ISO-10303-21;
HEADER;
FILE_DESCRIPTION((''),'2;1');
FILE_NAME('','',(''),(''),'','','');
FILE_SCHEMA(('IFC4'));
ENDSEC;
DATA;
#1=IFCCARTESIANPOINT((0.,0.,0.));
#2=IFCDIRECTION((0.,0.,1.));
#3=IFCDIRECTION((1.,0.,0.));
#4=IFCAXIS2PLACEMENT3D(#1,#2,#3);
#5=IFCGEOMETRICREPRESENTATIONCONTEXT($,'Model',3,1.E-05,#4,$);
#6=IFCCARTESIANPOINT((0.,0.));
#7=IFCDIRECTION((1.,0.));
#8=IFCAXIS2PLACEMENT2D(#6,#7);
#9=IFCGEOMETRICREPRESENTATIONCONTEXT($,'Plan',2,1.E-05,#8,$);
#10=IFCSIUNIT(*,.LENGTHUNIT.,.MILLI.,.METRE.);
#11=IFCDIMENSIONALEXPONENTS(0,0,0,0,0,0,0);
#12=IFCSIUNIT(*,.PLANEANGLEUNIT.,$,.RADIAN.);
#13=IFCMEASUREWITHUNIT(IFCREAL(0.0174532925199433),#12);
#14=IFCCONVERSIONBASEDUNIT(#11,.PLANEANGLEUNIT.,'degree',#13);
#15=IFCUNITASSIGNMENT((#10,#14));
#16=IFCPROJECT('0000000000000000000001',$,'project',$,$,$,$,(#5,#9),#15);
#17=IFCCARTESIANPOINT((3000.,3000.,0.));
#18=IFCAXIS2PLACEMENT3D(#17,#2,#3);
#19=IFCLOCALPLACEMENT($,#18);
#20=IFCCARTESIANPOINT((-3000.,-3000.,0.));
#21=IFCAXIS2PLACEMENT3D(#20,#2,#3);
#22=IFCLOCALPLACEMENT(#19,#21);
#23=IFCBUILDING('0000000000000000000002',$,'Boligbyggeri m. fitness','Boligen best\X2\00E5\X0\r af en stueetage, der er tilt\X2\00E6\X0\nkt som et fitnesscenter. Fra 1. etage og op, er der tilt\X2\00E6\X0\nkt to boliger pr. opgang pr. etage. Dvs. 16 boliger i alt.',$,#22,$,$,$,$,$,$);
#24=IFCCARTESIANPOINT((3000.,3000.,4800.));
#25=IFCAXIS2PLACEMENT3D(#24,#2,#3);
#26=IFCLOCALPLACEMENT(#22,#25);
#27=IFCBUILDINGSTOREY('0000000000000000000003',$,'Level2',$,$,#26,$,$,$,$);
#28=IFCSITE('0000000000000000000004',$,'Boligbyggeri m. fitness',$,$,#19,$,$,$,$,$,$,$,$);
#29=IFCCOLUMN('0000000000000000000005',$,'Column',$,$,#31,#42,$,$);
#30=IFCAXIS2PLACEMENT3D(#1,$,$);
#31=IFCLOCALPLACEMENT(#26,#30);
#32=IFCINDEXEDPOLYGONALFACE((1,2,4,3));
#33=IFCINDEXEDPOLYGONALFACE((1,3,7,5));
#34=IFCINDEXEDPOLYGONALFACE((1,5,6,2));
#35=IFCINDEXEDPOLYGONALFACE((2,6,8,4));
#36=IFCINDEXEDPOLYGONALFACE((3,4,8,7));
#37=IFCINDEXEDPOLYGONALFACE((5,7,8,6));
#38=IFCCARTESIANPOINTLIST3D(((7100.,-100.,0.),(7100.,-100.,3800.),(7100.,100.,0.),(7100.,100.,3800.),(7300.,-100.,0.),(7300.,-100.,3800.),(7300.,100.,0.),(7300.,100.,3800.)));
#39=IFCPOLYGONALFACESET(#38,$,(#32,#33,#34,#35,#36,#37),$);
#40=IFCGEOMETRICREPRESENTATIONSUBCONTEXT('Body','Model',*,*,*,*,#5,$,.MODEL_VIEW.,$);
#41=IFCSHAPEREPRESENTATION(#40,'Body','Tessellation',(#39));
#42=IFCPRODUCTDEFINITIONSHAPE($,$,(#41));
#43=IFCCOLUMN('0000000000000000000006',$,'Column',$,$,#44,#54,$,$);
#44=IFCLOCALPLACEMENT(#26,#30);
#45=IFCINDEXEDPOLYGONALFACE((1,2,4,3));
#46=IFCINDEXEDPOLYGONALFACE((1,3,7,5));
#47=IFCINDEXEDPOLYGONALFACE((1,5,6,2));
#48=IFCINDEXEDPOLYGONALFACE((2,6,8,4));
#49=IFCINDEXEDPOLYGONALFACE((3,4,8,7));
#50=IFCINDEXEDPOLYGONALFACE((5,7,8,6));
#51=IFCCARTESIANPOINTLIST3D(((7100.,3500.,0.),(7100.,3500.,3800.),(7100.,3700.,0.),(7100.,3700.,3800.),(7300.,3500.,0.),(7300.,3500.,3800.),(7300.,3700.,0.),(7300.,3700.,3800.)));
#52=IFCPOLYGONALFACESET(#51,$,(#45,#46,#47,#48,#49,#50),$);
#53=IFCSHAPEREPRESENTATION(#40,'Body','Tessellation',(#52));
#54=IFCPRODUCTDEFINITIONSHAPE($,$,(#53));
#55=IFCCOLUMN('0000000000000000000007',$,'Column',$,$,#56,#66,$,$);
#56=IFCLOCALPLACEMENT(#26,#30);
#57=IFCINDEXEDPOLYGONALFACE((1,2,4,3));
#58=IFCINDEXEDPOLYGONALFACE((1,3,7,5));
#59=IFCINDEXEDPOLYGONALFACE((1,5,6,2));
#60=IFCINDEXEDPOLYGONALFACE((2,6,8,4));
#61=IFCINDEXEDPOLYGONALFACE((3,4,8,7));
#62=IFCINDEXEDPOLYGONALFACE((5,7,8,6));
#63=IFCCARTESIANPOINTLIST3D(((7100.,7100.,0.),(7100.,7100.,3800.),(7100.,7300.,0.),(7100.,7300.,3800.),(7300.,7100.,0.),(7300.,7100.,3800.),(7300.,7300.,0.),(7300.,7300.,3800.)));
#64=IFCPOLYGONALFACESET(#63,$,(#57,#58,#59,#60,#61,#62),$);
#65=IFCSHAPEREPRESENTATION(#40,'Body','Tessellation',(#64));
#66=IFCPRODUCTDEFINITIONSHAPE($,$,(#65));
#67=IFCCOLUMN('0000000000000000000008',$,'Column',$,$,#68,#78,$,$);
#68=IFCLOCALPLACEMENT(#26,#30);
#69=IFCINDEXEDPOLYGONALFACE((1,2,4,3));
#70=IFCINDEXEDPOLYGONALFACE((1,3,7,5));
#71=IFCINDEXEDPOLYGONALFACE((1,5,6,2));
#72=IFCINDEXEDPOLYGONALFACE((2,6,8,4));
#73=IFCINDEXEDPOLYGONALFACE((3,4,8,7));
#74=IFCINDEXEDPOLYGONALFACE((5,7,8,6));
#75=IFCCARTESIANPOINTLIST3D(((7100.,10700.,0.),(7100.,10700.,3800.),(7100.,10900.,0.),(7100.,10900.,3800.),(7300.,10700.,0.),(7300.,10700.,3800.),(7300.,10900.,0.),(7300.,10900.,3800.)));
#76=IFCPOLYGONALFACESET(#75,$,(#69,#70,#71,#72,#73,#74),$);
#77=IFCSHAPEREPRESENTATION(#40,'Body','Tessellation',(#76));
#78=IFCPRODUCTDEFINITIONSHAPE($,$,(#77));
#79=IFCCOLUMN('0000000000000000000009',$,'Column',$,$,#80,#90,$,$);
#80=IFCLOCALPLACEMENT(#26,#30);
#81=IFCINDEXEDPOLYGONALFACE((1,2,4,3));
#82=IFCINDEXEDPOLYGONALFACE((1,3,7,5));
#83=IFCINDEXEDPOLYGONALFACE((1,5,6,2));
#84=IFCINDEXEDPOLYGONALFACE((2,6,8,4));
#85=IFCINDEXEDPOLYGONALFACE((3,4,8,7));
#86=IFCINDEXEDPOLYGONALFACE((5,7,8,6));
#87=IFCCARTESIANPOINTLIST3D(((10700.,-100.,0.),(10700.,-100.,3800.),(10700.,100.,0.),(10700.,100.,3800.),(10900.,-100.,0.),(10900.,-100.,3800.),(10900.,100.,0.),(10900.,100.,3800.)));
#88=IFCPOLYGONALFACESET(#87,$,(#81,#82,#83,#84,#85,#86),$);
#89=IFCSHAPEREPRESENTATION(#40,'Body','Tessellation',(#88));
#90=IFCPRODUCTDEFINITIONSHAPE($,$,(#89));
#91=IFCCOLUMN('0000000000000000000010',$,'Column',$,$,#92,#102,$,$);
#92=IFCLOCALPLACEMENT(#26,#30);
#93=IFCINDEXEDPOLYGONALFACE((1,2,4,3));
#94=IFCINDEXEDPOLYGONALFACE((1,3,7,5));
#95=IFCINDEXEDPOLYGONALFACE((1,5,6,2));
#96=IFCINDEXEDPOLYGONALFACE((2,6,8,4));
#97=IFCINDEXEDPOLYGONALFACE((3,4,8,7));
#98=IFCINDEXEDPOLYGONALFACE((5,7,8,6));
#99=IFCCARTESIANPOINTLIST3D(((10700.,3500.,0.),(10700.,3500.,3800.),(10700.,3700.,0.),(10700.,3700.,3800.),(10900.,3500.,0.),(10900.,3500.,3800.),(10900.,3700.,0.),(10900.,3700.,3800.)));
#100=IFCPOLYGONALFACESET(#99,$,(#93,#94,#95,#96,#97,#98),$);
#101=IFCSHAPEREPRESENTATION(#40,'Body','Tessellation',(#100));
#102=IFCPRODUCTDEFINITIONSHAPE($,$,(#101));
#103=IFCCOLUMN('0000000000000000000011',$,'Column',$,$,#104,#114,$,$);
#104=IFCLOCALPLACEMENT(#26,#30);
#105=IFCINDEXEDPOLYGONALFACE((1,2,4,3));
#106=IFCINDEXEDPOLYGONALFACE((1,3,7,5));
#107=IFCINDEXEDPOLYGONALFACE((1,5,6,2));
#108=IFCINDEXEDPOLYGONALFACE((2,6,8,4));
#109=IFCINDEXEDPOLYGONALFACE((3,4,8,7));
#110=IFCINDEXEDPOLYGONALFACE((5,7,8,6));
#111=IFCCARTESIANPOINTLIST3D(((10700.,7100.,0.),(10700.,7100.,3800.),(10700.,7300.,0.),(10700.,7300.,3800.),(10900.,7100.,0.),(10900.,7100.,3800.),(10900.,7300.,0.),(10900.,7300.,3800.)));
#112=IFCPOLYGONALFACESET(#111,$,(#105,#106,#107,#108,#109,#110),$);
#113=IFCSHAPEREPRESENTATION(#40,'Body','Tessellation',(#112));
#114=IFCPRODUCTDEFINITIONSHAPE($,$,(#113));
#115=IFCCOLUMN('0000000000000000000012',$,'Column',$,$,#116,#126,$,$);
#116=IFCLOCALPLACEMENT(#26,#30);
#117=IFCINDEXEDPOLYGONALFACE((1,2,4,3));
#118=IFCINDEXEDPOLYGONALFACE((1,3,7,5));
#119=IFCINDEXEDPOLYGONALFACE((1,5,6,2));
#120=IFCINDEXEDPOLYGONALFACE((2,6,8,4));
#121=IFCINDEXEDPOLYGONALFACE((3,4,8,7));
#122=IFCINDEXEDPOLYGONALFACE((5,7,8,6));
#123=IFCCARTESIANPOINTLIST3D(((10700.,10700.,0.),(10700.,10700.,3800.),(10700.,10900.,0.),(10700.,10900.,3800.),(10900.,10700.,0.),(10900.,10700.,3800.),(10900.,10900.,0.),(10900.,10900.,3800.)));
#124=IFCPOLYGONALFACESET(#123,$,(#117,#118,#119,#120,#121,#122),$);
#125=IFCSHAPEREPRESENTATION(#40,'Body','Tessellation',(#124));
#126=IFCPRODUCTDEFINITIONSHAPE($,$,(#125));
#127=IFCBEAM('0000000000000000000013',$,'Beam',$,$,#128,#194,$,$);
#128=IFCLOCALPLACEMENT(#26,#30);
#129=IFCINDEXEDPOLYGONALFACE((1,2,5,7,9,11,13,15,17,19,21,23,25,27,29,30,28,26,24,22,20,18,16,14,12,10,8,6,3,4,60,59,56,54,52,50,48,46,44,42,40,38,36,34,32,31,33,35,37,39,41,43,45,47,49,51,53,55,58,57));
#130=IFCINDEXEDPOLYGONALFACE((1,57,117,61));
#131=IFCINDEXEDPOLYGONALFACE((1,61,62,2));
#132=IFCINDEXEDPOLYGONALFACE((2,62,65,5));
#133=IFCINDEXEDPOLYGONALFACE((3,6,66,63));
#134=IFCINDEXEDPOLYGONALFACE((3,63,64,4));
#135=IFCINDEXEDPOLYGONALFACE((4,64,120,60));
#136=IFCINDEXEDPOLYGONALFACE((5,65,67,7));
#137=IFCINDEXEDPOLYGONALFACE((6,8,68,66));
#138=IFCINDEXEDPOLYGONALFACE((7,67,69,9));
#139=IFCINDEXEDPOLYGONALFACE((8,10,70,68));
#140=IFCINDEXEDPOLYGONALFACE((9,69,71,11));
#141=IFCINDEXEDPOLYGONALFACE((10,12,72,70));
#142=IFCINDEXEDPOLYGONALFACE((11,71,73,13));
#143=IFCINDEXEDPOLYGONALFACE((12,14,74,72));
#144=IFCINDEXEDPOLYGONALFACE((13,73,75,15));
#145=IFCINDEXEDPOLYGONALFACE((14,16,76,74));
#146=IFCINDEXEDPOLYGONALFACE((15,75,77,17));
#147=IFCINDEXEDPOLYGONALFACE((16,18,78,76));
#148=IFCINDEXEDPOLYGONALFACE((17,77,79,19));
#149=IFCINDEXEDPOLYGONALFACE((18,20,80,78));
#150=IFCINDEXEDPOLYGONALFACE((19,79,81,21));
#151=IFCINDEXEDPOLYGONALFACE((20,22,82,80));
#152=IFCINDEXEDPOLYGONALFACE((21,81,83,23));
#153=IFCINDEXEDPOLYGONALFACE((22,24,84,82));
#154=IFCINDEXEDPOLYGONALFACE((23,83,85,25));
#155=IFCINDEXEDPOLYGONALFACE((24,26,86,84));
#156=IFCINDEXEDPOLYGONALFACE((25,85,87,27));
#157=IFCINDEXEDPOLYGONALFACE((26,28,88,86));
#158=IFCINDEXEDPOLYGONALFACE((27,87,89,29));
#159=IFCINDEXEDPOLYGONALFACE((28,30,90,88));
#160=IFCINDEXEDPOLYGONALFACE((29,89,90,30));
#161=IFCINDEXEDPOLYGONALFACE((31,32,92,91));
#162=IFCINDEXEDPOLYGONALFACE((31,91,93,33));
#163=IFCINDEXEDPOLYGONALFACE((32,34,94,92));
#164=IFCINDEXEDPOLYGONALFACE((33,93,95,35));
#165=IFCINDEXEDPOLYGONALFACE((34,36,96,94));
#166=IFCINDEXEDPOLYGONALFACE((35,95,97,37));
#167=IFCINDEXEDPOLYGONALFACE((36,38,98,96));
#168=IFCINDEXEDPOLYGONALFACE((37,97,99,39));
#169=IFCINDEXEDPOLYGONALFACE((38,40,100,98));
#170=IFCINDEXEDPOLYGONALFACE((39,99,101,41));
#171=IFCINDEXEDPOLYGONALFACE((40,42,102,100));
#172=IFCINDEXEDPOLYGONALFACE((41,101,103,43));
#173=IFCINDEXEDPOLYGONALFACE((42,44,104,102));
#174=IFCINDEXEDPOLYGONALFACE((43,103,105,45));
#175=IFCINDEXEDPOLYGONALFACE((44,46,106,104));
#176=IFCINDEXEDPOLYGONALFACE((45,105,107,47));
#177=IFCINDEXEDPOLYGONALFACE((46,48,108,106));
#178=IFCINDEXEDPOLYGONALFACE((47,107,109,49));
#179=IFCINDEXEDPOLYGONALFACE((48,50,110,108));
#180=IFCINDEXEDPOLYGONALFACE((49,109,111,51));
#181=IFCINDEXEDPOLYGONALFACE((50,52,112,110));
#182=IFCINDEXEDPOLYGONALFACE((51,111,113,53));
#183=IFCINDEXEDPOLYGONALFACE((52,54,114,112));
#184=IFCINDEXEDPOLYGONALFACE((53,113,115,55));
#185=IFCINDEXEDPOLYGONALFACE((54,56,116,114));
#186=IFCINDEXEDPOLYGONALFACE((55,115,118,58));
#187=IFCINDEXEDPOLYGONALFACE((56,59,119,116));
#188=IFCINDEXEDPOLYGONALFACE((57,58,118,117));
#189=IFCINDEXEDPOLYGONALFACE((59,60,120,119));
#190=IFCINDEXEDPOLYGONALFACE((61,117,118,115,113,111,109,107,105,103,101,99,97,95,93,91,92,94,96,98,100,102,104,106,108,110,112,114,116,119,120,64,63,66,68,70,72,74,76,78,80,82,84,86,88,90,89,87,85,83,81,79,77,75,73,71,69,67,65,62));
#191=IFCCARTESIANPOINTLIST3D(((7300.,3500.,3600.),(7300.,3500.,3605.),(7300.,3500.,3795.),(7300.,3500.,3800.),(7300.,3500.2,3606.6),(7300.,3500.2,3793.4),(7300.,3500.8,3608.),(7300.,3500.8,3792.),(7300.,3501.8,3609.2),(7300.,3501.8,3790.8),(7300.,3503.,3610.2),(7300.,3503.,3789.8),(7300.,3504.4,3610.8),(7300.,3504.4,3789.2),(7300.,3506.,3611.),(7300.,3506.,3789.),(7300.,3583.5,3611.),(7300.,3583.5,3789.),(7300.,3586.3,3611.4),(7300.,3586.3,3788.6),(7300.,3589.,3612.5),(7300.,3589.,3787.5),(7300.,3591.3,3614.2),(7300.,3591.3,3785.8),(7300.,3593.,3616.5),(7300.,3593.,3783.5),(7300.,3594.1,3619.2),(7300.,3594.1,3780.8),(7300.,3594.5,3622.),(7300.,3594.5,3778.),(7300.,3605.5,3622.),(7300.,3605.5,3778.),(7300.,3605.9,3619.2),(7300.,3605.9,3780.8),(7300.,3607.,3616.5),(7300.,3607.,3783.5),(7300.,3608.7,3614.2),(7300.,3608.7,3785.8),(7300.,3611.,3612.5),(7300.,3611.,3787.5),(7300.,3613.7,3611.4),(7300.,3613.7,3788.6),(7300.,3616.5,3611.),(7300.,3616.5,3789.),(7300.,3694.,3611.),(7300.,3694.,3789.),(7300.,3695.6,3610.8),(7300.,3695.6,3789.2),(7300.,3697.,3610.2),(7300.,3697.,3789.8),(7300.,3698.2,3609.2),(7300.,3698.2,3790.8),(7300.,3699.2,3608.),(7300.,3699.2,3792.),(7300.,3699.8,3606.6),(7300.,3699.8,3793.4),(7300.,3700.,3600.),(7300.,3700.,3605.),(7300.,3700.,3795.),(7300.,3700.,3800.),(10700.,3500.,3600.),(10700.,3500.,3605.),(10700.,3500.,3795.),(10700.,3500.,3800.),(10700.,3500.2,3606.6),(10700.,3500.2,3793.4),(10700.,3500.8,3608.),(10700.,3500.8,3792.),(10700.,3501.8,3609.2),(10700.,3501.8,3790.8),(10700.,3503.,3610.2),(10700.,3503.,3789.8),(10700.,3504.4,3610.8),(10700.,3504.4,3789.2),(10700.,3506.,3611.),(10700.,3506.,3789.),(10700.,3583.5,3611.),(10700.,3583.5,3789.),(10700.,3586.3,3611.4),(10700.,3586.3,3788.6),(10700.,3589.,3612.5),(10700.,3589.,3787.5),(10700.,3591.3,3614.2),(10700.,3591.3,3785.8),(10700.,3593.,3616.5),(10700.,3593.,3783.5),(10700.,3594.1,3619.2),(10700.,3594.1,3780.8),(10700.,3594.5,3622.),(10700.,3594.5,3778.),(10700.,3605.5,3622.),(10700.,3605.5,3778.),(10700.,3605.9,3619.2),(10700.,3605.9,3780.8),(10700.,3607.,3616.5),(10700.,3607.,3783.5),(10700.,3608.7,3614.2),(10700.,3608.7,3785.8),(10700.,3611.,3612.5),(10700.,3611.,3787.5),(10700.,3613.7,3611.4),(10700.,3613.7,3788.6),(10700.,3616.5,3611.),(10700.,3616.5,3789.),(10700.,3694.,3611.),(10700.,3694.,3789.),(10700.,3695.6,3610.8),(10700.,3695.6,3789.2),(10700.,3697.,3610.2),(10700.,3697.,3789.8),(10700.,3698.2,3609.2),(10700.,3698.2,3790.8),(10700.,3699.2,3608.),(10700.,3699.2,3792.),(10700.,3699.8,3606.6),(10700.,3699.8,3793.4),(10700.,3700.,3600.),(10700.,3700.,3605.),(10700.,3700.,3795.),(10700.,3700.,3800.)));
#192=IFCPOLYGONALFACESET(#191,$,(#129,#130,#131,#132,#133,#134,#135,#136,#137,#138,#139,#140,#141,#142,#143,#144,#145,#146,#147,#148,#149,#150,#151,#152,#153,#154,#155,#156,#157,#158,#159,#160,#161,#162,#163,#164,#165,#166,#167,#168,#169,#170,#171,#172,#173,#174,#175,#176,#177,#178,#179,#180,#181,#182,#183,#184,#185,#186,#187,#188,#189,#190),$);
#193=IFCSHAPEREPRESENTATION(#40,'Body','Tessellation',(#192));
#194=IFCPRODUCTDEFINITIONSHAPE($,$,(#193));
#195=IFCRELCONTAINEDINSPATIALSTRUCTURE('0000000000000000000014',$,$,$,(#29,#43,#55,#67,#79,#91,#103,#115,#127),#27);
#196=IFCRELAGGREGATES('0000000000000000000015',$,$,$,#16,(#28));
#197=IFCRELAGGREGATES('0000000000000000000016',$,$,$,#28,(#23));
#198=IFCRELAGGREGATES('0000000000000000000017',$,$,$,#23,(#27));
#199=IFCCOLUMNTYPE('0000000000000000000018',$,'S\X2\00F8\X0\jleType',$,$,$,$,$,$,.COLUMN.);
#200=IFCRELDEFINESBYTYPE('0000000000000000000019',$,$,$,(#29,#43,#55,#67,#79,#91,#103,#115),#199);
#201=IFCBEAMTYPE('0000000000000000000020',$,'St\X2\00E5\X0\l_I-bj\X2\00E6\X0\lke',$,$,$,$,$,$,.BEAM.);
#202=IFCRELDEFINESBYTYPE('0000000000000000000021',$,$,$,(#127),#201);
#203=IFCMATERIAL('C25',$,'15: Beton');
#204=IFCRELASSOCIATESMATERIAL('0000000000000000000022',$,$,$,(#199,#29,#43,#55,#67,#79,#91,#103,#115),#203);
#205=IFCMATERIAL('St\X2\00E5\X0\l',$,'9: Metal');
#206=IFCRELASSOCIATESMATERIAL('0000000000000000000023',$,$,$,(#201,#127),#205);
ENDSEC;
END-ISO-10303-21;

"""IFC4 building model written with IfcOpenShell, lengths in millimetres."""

from ifc_helpers import new_model, entity, si_unit, converted_unit, frame, origin_with_axes, origin_2d_with_axis, place, context, subcontext, project, spatial, rectangle, i_section, extrude, material, material_profile, profile_set, profile_usage, type_object, element, save


model = new_model("IFC4")

# Units and contexts
model_context = context("Model", 3, precision=1e-05, world=origin_with_axes())
plan_context = context("Plan", 2, precision=1e-05, world=origin_2d_with_axis())
body_context = subcontext(model_context, "Body", "Model", "MODEL_VIEW")
ifc_project = project(units=[si_unit("LENGTHUNIT", "METRE", prefix="MILLI"), converted_unit("PLANEANGLEUNIT", "degree", entity("IfcReal", 0.0174532925199433), si_unit("PLANEANGLEUNIT", "RADIAN"), dimensions=[0, 0, 0, 0, 0, 0, 0])], contexts=[model_context, plan_context])

# Site, building, storey
site_placement = place(None, frame((3000.0, 3000.0, 0.0), z_axis=(0.0, 0.0, 1.0), x_axis=(1.0, 0.0, 0.0)))
site = spatial("IfcSite", under=ifc_project, at=site_placement, Name="Boligbyggeri m. fitness")
building_placement = place(site_placement, frame((-3000.0, -3000.0, 0.0), z_axis=(0.0, 0.0, 1.0), x_axis=(1.0, 0.0, 0.0)))
building = spatial("IfcBuilding", under=site, at=building_placement, Name="Boligbyggeri m. fitness", Description="Boligen består af en stueetage, der er tiltænkt som et fitnesscenter. Fra 1. etage og op, er der tiltænkt to boliger pr. opgang pr. etage. Dvs. 16 boliger i alt.")
storey_placement = place(building_placement, frame((3000.0, 3000.0, 4800.0), z_axis=(0.0, 0.0, 1.0), x_axis=(1.0, 0.0, 0.0)))
storey = spatial("IfcBuildingStorey", under=building, at=storey_placement, Name="Level2")

# Columns
ifc_material_1 = material(Name="C25", Category="15: Beton")
ifc_material_profile_1 = material_profile(ifc_material_1, rectangle(XDim=200.0, YDim=200.0), Name="SøjleBeton", Category="15: Beton")
ifc_profile_set_1 = profile_set([ifc_material_profile_1], Name="200x200")
ifc_profile_usage_1 = profile_usage(ifc_profile_set_1, cardinal=5)
column_type = type_object("IfcColumnType", Name="SøjleType", PredefinedType="COLUMN", material=ifc_profile_set_1)
column_1_placement = place(storey_placement, frame((7200.0, 0.0, 0.0), z_axis=(0.0, 0.0, 1.0), x_axis=(1.0, 0.0, 0.0)))
element("IfcColumn", 1, at=column_1_placement, inside=storey, type_object=column_type, material=ifc_profile_usage_1, Name="Column", context=body_context, shape_type="SweptSolid", body=[
    extrude(rectangle(XDim=200.0, YDim=200.0), origin_with_axes(), (0.0, 0.0, 1.0), 3800.0),
])
ifc_profile_usage_2 = profile_usage(ifc_profile_set_1, cardinal=5)
column_2_placement = place(storey_placement, frame((7200.0, 3600.0, 0.0), z_axis=(0.0, 0.0, 1.0), x_axis=(1.0, 0.0, 0.0)))
element("IfcColumn", 2, at=column_2_placement, inside=storey, type_object=column_type, material=ifc_profile_usage_2, Name="Column", context=body_context, shape_type="SweptSolid", body=[
    extrude(rectangle(XDim=200.0, YDim=200.0), origin_with_axes(), (0.0, 0.0, 1.0), 3800.0),
])
ifc_profile_usage_3 = profile_usage(ifc_profile_set_1, cardinal=5)
column_3_placement = place(storey_placement, frame((7200.0, 7200.0, 0.0), z_axis=(0.0, 0.0, 1.0), x_axis=(1.0, 0.0, 0.0)))
element("IfcColumn", 3, at=column_3_placement, inside=storey, type_object=column_type, material=ifc_profile_usage_3, Name="Column", context=body_context, shape_type="SweptSolid", body=[
    extrude(rectangle(XDim=200.0, YDim=200.0), origin_with_axes(), (0.0, 0.0, 1.0), 3800.0),
])
ifc_profile_usage_4 = profile_usage(ifc_profile_set_1, cardinal=5)
column_4_placement = place(storey_placement, frame((7200.0, 10800.0, 0.0), z_axis=(0.0, 0.0, 1.0), x_axis=(1.0, 0.0, 0.0)))
element("IfcColumn", 4, at=column_4_placement, inside=storey, type_object=column_type, material=ifc_profile_usage_4, Name="Column", context=body_context, shape_type="SweptSolid", body=[
    extrude(rectangle(XDim=200.0, YDim=200.0), origin_with_axes(), (0.0, 0.0, 1.0), 3800.0),
])
ifc_profile_usage_5 = profile_usage(ifc_profile_set_1, cardinal=5)
column_5_placement = place(storey_placement, frame((10800.0, 0.0, 0.0), z_axis=(0.0, 0.0, 1.0), x_axis=(1.0, 0.0, 0.0)))
element("IfcColumn", 5, at=column_5_placement, inside=storey, type_object=column_type, material=ifc_profile_usage_5, Name="Column", context=body_context, shape_type="SweptSolid", body=[
    extrude(rectangle(XDim=200.0, YDim=200.0), origin_with_axes(), (0.0, 0.0, 1.0), 3800.0),
])
ifc_profile_usage_6 = profile_usage(ifc_profile_set_1, cardinal=5)
column_6_placement = place(storey_placement, frame((10800.0, 3600.0, 0.0), z_axis=(0.0, 0.0, 1.0), x_axis=(1.0, 0.0, 0.0)))
element("IfcColumn", 6, at=column_6_placement, inside=storey, type_object=column_type, material=ifc_profile_usage_6, Name="Column", context=body_context, shape_type="SweptSolid", body=[
    extrude(rectangle(XDim=200.0, YDim=200.0), origin_with_axes(), (0.0, 0.0, 1.0), 3800.0),
])
ifc_profile_usage_7 = profile_usage(ifc_profile_set_1, cardinal=5)
column_7_placement = place(storey_placement, frame((10800.0, 7200.0, 0.0), z_axis=(0.0, 0.0, 1.0), x_axis=(1.0, 0.0, 0.0)))
element("IfcColumn", 7, at=column_7_placement, inside=storey, type_object=column_type, material=ifc_profile_usage_7, Name="Column", context=body_context, shape_type="SweptSolid", body=[
    extrude(rectangle(XDim=200.0, YDim=200.0), origin_with_axes(), (0.0, 0.0, 1.0), 3800.0),
])
ifc_profile_usage_8 = profile_usage(ifc_profile_set_1, cardinal=5)
column_8_placement = place(storey_placement, frame((10800.0, 10800.0, 0.0), z_axis=(0.0, 0.0, 1.0), x_axis=(1.0, 0.0, 0.0)))
element("IfcColumn", 8, at=column_8_placement, inside=storey, type_object=column_type, material=ifc_profile_usage_8, Name="Column", context=body_context, shape_type="SweptSolid", body=[
    extrude(rectangle(XDim=200.0, YDim=200.0), origin_with_axes(), (0.0, 0.0, 1.0), 3800.0),
])

# Beam
ifc_material_2 = material(Name="Stål", Category="9: Metal")
ifc_material_profile_2 = material_profile(ifc_material_2, i_section(OverallWidth=200.0, OverallDepth=200.0, WebThickness=11.0, FlangeThickness=11.0, FilletRadius=11.0, FlangeEdgeRadius=6.0), Name="Stål", Category="9: Metal")
ifc_profile_set_2 = profile_set([ifc_material_profile_2], Name="NY_I-Profil")
ifc_profile_usage_9 = profile_usage(ifc_profile_set_2, cardinal=7)
beam_type = type_object("IfcBeamType", Name="Stål_I-bjælke", PredefinedType="BEAM", material=ifc_profile_set_2)
beam_1_placement = place(storey_placement, frame((7300.0, 3700.0, 3800.0), z_axis=(1.0, 0.0, 0.0), x_axis=(0.0, 1.0, 0.0)))
element("IfcBeam", 9, at=beam_1_placement, inside=storey, type_object=beam_type, material=ifc_profile_usage_9, Name="Beam", context=body_context, shape_type="SweptSolid", body=[
    extrude(i_section(OverallWidth=200.0, OverallDepth=200.0, WebThickness=11.0, FlangeThickness=11.0, FilletRadius=11.0, FlangeEdgeRadius=6.0), frame((-100.0, -100.0, 0.0), z_axis=(0.0, 0.0, 1.0), x_axis=(1.0, 0.0, 0.0)), (0.0, 0.0, 1.0), 3400.0),
])

save(model, "model.ifc")
